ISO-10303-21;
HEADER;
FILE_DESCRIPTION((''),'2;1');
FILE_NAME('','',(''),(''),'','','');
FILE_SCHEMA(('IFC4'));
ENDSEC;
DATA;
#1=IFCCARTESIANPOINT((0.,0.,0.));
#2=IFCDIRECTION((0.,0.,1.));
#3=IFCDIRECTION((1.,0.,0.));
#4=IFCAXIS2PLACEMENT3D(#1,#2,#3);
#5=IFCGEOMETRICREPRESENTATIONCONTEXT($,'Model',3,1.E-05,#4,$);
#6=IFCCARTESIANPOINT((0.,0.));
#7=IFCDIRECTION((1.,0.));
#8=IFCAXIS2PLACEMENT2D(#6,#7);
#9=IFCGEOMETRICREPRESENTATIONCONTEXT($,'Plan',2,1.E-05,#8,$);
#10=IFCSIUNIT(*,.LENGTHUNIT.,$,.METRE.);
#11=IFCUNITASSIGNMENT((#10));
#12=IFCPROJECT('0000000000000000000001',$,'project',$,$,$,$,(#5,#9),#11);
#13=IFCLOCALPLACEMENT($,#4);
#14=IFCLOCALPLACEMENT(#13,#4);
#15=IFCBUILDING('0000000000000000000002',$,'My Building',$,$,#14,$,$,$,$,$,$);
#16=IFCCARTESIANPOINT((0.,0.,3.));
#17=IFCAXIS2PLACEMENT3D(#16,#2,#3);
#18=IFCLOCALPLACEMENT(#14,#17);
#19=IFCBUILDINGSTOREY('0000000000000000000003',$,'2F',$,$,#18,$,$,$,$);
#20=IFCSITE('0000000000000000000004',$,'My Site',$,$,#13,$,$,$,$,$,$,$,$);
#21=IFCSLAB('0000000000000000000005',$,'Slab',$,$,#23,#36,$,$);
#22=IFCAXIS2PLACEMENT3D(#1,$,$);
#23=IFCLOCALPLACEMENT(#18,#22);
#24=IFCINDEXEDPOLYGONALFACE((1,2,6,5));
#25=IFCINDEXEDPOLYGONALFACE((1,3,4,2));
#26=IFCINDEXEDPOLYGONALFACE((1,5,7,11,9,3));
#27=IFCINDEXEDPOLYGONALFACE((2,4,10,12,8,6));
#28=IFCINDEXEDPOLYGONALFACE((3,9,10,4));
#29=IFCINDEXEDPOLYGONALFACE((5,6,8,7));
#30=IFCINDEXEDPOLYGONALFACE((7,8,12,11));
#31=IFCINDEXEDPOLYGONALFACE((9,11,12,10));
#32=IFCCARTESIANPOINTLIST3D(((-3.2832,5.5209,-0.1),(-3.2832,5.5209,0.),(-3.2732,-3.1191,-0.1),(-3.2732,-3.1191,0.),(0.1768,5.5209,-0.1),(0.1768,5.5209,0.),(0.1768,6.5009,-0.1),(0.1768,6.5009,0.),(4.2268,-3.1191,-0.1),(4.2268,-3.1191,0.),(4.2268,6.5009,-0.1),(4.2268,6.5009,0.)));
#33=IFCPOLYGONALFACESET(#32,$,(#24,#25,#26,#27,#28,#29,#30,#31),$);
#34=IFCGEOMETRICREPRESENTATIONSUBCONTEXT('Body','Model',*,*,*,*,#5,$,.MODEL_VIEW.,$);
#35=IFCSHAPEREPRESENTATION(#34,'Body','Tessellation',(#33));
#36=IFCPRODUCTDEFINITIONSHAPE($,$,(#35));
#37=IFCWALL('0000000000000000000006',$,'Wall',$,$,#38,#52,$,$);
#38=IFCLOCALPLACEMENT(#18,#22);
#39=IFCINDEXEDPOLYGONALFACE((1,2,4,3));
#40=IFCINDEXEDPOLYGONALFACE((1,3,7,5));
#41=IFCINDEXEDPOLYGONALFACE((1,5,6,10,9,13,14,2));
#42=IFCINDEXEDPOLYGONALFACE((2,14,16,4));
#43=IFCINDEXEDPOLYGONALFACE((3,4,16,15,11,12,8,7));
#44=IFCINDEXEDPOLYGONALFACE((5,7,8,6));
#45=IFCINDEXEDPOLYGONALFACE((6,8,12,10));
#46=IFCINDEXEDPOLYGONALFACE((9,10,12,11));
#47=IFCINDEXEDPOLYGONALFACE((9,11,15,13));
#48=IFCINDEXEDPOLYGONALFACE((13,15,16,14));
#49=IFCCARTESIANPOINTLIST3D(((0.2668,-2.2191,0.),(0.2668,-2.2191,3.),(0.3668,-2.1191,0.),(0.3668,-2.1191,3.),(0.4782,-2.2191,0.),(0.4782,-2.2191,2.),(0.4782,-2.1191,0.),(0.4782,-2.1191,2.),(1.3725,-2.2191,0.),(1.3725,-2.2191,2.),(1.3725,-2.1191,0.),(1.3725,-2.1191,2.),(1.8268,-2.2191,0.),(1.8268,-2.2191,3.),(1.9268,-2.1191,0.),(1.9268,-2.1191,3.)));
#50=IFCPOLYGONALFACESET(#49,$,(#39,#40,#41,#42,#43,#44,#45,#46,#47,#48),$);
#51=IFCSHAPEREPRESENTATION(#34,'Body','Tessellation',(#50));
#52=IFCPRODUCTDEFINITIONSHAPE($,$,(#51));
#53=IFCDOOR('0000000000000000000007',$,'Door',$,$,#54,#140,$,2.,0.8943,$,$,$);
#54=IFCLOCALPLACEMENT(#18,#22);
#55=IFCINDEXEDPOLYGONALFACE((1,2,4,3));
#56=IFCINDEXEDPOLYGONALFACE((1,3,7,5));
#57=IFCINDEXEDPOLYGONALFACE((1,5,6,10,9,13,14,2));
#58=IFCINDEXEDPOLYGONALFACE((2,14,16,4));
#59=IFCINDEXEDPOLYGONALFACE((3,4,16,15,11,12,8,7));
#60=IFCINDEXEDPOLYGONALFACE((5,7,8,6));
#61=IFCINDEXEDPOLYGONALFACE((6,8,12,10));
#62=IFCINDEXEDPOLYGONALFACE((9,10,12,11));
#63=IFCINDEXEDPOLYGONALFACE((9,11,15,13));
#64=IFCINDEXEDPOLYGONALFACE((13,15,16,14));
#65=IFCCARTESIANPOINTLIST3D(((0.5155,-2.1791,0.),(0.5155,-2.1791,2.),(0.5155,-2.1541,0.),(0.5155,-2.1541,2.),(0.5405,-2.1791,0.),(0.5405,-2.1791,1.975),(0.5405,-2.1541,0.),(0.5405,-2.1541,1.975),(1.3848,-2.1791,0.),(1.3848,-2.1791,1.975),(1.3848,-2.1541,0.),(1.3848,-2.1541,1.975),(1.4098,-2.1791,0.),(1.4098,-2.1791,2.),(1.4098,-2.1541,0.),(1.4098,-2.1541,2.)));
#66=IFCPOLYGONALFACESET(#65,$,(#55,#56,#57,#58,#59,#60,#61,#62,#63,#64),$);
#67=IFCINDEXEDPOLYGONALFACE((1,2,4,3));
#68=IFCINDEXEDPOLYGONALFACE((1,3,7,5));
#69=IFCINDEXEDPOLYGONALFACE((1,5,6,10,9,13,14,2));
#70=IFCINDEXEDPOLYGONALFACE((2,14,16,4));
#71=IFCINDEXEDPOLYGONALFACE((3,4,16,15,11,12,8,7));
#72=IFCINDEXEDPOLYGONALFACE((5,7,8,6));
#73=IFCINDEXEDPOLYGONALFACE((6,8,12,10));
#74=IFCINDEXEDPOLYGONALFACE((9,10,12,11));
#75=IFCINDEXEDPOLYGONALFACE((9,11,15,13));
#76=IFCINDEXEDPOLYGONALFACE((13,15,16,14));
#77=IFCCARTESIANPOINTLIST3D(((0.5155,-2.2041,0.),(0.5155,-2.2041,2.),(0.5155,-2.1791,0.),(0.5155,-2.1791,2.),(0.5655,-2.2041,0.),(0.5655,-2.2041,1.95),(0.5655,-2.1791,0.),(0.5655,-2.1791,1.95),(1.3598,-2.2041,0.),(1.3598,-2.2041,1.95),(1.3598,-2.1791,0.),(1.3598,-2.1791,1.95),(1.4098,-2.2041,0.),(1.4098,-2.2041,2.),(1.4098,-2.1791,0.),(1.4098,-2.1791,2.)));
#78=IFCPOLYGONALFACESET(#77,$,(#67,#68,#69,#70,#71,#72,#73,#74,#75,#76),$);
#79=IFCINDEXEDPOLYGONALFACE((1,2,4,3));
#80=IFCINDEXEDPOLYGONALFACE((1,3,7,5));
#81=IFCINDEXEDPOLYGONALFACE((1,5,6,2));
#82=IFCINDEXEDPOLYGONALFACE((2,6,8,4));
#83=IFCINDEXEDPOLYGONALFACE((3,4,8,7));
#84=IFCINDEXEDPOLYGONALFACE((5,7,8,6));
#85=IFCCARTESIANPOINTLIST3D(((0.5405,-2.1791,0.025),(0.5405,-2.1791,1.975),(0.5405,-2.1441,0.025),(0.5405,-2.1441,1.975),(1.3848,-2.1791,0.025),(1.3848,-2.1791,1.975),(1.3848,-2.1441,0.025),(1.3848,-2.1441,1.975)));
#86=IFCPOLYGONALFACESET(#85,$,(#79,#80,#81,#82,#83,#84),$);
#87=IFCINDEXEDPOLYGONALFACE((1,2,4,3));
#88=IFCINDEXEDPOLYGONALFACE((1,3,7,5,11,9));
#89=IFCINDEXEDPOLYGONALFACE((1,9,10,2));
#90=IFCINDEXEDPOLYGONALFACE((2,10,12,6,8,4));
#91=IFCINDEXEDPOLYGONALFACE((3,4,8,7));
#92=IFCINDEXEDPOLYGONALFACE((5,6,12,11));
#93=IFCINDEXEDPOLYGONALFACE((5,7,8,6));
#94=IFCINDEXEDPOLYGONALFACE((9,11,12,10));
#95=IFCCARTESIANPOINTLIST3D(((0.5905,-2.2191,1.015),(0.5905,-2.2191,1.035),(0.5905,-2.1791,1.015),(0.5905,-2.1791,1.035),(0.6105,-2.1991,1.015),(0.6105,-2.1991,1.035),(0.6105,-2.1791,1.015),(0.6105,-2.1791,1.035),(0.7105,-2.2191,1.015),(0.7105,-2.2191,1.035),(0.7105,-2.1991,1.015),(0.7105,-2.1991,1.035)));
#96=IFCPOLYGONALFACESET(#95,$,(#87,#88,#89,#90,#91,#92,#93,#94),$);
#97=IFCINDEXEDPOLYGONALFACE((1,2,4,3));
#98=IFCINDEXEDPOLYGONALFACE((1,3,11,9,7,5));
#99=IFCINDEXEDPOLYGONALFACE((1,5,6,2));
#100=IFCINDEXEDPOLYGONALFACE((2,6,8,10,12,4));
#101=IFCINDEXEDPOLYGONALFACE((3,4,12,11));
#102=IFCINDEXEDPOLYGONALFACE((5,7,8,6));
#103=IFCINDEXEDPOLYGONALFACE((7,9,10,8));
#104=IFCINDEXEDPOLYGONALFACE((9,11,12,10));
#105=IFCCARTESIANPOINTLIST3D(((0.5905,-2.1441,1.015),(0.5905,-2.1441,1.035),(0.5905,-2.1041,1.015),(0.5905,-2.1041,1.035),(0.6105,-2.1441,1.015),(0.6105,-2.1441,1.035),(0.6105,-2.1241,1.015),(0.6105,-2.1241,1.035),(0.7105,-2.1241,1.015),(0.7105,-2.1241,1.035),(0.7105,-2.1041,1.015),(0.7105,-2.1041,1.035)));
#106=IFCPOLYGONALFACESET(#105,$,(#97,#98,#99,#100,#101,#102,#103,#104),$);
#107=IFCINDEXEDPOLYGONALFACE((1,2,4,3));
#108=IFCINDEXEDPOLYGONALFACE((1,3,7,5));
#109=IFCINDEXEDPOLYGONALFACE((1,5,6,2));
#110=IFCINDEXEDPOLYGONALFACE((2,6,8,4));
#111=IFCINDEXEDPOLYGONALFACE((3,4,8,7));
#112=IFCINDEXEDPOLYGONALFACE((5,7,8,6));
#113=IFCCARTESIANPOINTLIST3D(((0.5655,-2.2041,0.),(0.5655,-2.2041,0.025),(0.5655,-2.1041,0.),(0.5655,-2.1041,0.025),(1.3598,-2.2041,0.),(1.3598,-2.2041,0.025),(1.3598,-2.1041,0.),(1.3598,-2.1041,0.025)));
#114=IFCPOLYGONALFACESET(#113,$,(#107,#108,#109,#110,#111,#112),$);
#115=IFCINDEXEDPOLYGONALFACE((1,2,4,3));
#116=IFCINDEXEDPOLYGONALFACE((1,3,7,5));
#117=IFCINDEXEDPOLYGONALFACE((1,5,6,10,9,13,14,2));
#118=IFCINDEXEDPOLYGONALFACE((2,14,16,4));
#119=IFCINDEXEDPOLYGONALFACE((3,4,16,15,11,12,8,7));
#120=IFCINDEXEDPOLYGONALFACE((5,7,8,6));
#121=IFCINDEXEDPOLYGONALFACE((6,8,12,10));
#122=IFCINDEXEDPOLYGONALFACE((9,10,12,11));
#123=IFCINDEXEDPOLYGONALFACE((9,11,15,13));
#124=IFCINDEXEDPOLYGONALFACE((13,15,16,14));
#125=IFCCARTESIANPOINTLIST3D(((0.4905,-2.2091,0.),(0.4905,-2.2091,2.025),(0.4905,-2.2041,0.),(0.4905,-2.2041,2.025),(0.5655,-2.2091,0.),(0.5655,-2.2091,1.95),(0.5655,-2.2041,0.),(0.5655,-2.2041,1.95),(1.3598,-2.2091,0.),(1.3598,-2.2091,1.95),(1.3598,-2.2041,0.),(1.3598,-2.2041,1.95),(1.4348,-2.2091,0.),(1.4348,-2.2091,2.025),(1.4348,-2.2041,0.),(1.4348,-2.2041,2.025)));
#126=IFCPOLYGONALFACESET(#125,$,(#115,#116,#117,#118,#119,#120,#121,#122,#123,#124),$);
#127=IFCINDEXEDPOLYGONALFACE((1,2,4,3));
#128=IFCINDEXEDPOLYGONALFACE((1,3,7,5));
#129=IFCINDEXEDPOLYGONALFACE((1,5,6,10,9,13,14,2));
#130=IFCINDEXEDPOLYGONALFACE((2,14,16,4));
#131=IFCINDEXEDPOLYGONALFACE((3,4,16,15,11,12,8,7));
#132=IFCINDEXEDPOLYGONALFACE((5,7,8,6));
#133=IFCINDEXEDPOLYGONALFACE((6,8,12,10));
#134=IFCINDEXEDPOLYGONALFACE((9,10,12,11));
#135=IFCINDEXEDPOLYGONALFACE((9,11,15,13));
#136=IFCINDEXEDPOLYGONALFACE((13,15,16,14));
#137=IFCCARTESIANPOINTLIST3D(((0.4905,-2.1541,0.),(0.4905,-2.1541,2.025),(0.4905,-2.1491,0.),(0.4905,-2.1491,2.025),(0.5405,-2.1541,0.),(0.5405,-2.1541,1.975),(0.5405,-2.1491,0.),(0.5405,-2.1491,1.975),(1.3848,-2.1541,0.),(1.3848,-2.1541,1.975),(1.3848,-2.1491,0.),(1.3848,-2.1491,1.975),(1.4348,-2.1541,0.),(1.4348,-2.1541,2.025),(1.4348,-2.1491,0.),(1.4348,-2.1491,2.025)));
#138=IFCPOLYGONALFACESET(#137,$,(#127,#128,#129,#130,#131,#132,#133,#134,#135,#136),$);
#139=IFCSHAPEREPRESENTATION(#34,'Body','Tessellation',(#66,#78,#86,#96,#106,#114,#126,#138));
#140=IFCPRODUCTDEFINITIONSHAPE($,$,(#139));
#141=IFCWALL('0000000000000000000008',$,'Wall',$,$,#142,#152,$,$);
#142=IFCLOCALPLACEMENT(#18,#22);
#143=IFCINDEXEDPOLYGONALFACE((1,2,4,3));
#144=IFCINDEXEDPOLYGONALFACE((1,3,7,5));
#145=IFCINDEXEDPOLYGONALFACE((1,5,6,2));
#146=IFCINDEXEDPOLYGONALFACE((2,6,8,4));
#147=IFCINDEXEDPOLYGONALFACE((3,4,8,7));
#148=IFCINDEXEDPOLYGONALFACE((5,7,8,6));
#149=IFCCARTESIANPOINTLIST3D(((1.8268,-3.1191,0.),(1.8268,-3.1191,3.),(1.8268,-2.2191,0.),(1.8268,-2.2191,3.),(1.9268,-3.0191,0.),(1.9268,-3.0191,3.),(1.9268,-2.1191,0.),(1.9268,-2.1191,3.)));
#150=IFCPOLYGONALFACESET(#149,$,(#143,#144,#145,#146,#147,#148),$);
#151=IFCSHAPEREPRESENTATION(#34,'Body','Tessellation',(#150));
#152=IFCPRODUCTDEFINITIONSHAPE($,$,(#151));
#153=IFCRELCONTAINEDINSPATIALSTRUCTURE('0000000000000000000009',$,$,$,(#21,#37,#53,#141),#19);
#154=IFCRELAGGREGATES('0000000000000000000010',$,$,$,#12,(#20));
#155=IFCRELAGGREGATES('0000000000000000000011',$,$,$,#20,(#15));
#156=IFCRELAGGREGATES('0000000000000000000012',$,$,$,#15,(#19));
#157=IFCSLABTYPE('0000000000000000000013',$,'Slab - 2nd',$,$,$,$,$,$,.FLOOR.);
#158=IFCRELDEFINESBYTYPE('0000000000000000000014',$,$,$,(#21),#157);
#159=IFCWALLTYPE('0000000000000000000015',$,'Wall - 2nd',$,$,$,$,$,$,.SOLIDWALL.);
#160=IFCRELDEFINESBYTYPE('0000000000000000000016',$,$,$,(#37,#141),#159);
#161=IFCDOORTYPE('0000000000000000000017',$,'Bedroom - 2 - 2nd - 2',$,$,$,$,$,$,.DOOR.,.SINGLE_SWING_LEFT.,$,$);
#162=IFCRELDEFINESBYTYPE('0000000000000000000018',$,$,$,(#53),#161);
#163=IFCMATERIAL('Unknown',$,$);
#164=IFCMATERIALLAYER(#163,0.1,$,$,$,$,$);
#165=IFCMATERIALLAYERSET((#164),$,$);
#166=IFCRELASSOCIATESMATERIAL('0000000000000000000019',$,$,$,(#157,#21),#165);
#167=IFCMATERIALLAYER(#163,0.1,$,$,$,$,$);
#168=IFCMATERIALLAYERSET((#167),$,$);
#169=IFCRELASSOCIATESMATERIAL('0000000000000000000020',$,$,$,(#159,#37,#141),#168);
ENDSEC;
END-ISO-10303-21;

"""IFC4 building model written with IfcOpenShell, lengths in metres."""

from ifc_helpers import new_model, entity, si_unit, frame, origin_with_axes, origin_2d_with_axis, place, context, subcontext, project, spatial, line, indexed_curve, outline, extrude, shape, source, transform, mapped, material, layer, layer_set, layer_usage, type_object, type_shapes, element, fill, save


model = new_model("IFC4")

# Units and contexts
model_context = context("Model", 3, precision=1e-05, world=origin_with_axes())
plan_context = context("Plan", 2, precision=1e-05, world=origin_2d_with_axis())
body_context_1 = subcontext(model_context, "Body", "Model", "MODEL_VIEW")
body_context_2 = subcontext(plan_context, "Body", "Plan", "PLAN_VIEW")
ifc_project = project(units=[si_unit("LENGTHUNIT", "METRE")], contexts=[model_context, plan_context])

# Site, building, storey
site_placement = place(None, origin_with_axes())
site = spatial("IfcSite", under=ifc_project, at=site_placement, Name="My Site")
building_placement = place(site_placement, origin_with_axes())
building = spatial("IfcBuilding", under=site, at=building_placement, Name="My Building")
storey_placement = place(building_placement, frame((0.0, 0.0, 3.0), z_axis=(0.0, 0.0, 1.0), x_axis=(1.0, 0.0, 0.0)))
storey = spatial("IfcBuildingStorey", under=building, at=storey_placement, Name="2F")

# Slab
ifc_material = material(Name="Unknown")
ifc_layer_1 = layer(ifc_material, 0.1)
ifc_layer_set_1 = layer_set([ifc_layer_1])
ifc_layer_usage_1 = layer_usage(ifc_layer_set_1, "AXIS3", "POSITIVE", -0.1)
slab_type = type_object("IfcSlabType", Name="Slab - 2nd", PredefinedType="FLOOR", material=ifc_layer_set_1)
slab_placement = place(storey_placement, frame((4.2268, -3.1191, 0.0), z_axis=(0.0, 0.0, 1.0), x_axis=(1.0, 0.0, 0.0)))
element("IfcSlab", 1, at=slab_placement, inside=storey, type_object=slab_type, material=ifc_layer_usage_1, Name="Slab", context=body_context_1, shape_type="SweptSolid", body=[
    extrude(outline(indexed_curve([(0.0, 0.0), (-7.5, 0.0), (-7.51, 8.64), (-4.05, 8.64), (-4.05, 9.62), (0.0, 9.62), (0.0, 0.0)])), frame((0.0, 0.0, -0.1), z_axis=(0.0, 0.0, 1.0), x_axis=(1.0, 0.0, 0.0)), (0.0, 0.0, 1.0), 0.1),
])

# Wall, opening, door
ifc_layer_2 = layer(ifc_material, 0.1)
ifc_layer_set_2 = layer_set([ifc_layer_2])
ifc_layer_usage_2 = layer_usage(ifc_layer_set_2, "AXIS2", "POSITIVE", 0.0)
wall_type = type_object("IfcWallType", Name="Wall - 2nd", PredefinedType="SOLIDWALL", material=ifc_layer_set_2)
wall_1_placement = place(storey_placement, frame((0.2668, -2.2191, 0.0), z_axis=(0.0, 0.0, 1.0), x_axis=(1.0, 0.0, 0.0)))
wall_1 = element("IfcWall", 2, at=wall_1_placement, inside=storey, type_object=wall_type, material=ifc_layer_usage_2, Name="Wall", context=body_context_1, shape_type="SweptSolid", body=[
    extrude(outline(indexed_curve([(0.0, 0.0), (0.1, 0.1), (1.66, 0.1), (1.56, 0.0)], segments=[line(1, 2, 3, 4, 1)])), origin_with_axes(), (0.0, 0.0, 1.0), 3.0),
])
shared_shape_1 = source(origin_with_axes(), body_context_1, "Body", "SweptSolid", [
    extrude(outline(indexed_curve([(0.0, 0.0), (0.8943, 0.0), (0.8943, 2.0), (0.0, 2.0)], segments=[line(1, 2, 3, 4, 1)])), frame((0.0, -0.6, 0.0), z_axis=(0.0, -1.0, 0.0), x_axis=(1.0, 0.0, 0.0)), (0.0, 0.0, -1.0), 1.2),
])
opening_1_placement = place(wall_1_placement, frame((1.1056, 0.1, 0.0), z_axis=(0.0, 0.0, 1.0), x_axis=(-1.0, 0.0, 0.0)))
opening_1 = element("IfcOpeningElement", 3, at=opening_1_placement, cuts=wall_1, PredefinedType="OPENING", context=body_context_1, shape_type="MappedRepresentation", body=[
    mapped(shared_shape_1, transform((0.0, 0.0, 0.0), x_axis=(1.0, 0.0, 0.0), y_axis=(0.0, 1.0, 0.0), z_axis=(0.0, 0.0, 1.0), scale=1.0)),
])
door_type_1 = type_object("IfcDoorType", Name="Bedroom - 2 - 2nd - 2", OperationType="SINGLE_SWING_LEFT", PredefinedType="DOOR")
shared_shape_2 = source(origin_with_axes(), body_context_1, "Body", "SweptSolid", [
    extrude(outline(indexed_curve([(0.0, 0.0), (0.0, 2.0), (0.8943, 2.0), (0.8943, 0.0), (0.8693, 0.0), (0.8693, 1.975), (0.025, 1.975), (0.025, 0.0)], segments=[line(1, 2, 3, 4, 5, 6, 7, 8, 1)])), frame((0.0, 0.025, 0.0), z_axis=(0.0, -1.0, 0.0), x_axis=(1.0, 0.0, 0.0)), (0.0, 0.0, -1.0), 0.025),
    extrude(outline(indexed_curve([(0.0, 0.0), (0.0, 2.0), (0.8943, 2.0), (0.8943, 0.0), (0.8443, 0.0), (0.8443, 1.95), (0.05, 1.95), (0.05, 0.0)], segments=[line(1, 2, 3, 4, 5, 6, 7, 8, 1)])), frame((0.0, 0.0, 0.0), z_axis=(0.0, -1.0, 0.0), x_axis=(1.0, 0.0, 0.0)), (0.0, 0.0, -1.0), 0.025),
    extrude(outline(indexed_curve([(0.0, 0.0), (0.8443, 0.0), (0.8443, 0.035), (0.0, 0.035)], segments=[line(1, 2, 3, 4, 1)])), frame((0.025, 0.025, 0.025), z_axis=(0.0, 0.0, 1.0), x_axis=(1.0, 0.0, 0.0)), (0.0, 0.0, 1.0), 1.95),
    extrude(outline(indexed_curve([(0.0, 0.0), (0.0, -0.04), (0.12, -0.04), (0.12, -0.02), (0.02, -0.02), (0.02, 0.0)], segments=[line(1, 2, 3, 4, 5, 6, 1)])), frame((0.075, 0.025, 1.015), z_axis=(0.0, 0.0, 1.0), x_axis=(1.0, 0.0, 0.0)), (0.0, 0.0, 1.0), 0.02),
    extrude(outline(indexed_curve([(0.0, 0.0), (0.0, 0.04), (0.12, 0.04), (0.12, 0.02), (0.02, 0.02), (0.02, 0.0)], segments=[line(1, 2, 3, 4, 5, 6, 1)])), frame((0.075, 0.06, 1.015), z_axis=(0.0, 0.0, 1.0), x_axis=(1.0, 0.0, 0.0)), (0.0, 0.0, 1.0), 0.02),
    extrude(outline(indexed_curve([(0.0, 0.0), (0.7943, 0.0), (0.7943, 0.1), (0.0, 0.1)], segments=[line(1, 2, 3, 4, 1)])), frame((0.05, 0.0, 0.0), z_axis=(0.0, 0.0, 1.0), x_axis=(1.0, 0.0, 0.0)), (0.0, 0.0, 1.0), 0.025),
    extrude(outline(indexed_curve([(0.0, 0.0), (0.0, 2.025), (0.9443, 2.025), (0.9443, 0.0), (0.8693, 0.0), (0.8693, 1.95), (0.075, 1.95), (0.075, 0.0)], segments=[line(1, 2, 3, 4, 5, 6, 7, 8, 1)])), frame((-0.025, -0.005, 0.0), z_axis=(0.0, -1.0, 0.0), x_axis=(1.0, 0.0, 0.0)), (0.0, 0.0, -1.0), 0.005),
    extrude(outline(indexed_curve([(0.0, 0.0), (0.0, 2.025), (0.9443, 2.025), (0.9443, 0.0), (0.8943, 0.0), (0.8943, 1.975), (0.05, 1.975), (0.05, 0.0)], segments=[line(1, 2, 3, 4, 5, 6, 7, 8, 1)])), frame((-0.025, 0.05, 0.0), z_axis=(0.0, -1.0, 0.0), x_axis=(1.0, 0.0, 0.0)), (0.0, 0.0, -1.0), 0.005),
])
shared_shape_3 = source(origin_with_axes(), body_context_2, "Body", "Curve2D", [
    entity("IfcIndexedPolyCurve", entity("IfcCartesianPointList2D", [[0.0, 0.0], [0.0, 0.05], [0.025, 0.05], [0.025, 0.025], [0.05, 0.025], [0.05, 0.0]]), [entity("IfcLineIndex", [1, 2, 3, 4, 5, 6, 1])]),
    entity("IfcIndexedPolyCurve", entity("IfcCartesianPointList2D", [[0.8943, 0.0], [0.8943, 0.05], [0.8693, 0.05], [0.8693, 0.025], [0.8443, 0.025], [0.8443, 0.0]]), [entity("IfcLineIndex", [1, 2, 3, 4, 5, 6, 1])]),
    entity("IfcTrimmedCurve", entity("IfcEllipse", entity("IfcAxis2Placement2D", entity("IfcCartesianPoint", [0.8343, 0.05]), entity("IfcDirection", [1.0, 0.0])), 0.8093, 0.8443), [entity("IfcCartesianPoint", [0.8343, 0.8943])], [entity("IfcCartesianPoint", [0.025, 0.05])], True, "CARTESIAN"),
    entity("IfcIndexedPolyCurve", entity("IfcCartesianPointList2D", [[0.8693, 0.05], [0.8343, 0.05], [0.8343, 0.8943], [0.8693, 0.8943]]), [entity("IfcLineIndex", [1, 2, 3, 4, 1])]),
])
type_shapes(door_type_1, [shared_shape_2, shared_shape_3])
door_1_placement = place(opening_1_placement, frame((0.8569, 0.085, 0.0), z_axis=(0.0, 0.0, 1.0), x_axis=(-1.0, 0.0, 0.0)))
door_1 = element("IfcDoor", 4, at=door_1_placement, inside=storey, type_object=door_type_1, Name="Door", OverallHeight=2.0, OverallWidth=0.8943, shapes=[
    shape(body_context_1, "Body", "MappedRepresentation", [mapped(shared_shape_2, transform((0.0, 0.0, 0.0), x_axis=(1.0, 0.0, 0.0), y_axis=(0.0, 1.0, 0.0), z_axis=(0.0, 0.0, 1.0), scale=1.0))]),
    shape(body_context_2, "Body", "MappedRepresentation", [mapped(shared_shape_3, transform((0.0, 0.0, 0.0), x_axis=(1.0, 0.0, 0.0), y_axis=(0.0, 1.0, 0.0), z_axis=(0.0, 0.0, 1.0), scale=1.0))]),
])
fill(opening_1, door_1)

# Wall
ifc_layer_usage_3 = layer_usage(ifc_layer_set_2, "AXIS2", "POSITIVE", 0.0)
wall_2_placement = place(storey_placement, frame((1.8268, -2.2191, 0.0), z_axis=(0.0, 0.0, 1.0), x_axis=(0.0, -1.0, 0.0)))
element("IfcWall", 5, at=wall_2_placement, inside=storey, type_object=wall_type, material=ifc_layer_usage_3, Name="Wall", context=body_context_1, shape_type="SweptSolid", body=[
    extrude(outline(indexed_curve([(0.0, 0.0), (-0.1, 0.1), (0.8, 0.1), (0.9, 0.0)], segments=[line(1, 2, 3, 4, 1)])), origin_with_axes(), (0.0, 0.0, 1.0), 3.0),
])

save(model, "model.ifc")
